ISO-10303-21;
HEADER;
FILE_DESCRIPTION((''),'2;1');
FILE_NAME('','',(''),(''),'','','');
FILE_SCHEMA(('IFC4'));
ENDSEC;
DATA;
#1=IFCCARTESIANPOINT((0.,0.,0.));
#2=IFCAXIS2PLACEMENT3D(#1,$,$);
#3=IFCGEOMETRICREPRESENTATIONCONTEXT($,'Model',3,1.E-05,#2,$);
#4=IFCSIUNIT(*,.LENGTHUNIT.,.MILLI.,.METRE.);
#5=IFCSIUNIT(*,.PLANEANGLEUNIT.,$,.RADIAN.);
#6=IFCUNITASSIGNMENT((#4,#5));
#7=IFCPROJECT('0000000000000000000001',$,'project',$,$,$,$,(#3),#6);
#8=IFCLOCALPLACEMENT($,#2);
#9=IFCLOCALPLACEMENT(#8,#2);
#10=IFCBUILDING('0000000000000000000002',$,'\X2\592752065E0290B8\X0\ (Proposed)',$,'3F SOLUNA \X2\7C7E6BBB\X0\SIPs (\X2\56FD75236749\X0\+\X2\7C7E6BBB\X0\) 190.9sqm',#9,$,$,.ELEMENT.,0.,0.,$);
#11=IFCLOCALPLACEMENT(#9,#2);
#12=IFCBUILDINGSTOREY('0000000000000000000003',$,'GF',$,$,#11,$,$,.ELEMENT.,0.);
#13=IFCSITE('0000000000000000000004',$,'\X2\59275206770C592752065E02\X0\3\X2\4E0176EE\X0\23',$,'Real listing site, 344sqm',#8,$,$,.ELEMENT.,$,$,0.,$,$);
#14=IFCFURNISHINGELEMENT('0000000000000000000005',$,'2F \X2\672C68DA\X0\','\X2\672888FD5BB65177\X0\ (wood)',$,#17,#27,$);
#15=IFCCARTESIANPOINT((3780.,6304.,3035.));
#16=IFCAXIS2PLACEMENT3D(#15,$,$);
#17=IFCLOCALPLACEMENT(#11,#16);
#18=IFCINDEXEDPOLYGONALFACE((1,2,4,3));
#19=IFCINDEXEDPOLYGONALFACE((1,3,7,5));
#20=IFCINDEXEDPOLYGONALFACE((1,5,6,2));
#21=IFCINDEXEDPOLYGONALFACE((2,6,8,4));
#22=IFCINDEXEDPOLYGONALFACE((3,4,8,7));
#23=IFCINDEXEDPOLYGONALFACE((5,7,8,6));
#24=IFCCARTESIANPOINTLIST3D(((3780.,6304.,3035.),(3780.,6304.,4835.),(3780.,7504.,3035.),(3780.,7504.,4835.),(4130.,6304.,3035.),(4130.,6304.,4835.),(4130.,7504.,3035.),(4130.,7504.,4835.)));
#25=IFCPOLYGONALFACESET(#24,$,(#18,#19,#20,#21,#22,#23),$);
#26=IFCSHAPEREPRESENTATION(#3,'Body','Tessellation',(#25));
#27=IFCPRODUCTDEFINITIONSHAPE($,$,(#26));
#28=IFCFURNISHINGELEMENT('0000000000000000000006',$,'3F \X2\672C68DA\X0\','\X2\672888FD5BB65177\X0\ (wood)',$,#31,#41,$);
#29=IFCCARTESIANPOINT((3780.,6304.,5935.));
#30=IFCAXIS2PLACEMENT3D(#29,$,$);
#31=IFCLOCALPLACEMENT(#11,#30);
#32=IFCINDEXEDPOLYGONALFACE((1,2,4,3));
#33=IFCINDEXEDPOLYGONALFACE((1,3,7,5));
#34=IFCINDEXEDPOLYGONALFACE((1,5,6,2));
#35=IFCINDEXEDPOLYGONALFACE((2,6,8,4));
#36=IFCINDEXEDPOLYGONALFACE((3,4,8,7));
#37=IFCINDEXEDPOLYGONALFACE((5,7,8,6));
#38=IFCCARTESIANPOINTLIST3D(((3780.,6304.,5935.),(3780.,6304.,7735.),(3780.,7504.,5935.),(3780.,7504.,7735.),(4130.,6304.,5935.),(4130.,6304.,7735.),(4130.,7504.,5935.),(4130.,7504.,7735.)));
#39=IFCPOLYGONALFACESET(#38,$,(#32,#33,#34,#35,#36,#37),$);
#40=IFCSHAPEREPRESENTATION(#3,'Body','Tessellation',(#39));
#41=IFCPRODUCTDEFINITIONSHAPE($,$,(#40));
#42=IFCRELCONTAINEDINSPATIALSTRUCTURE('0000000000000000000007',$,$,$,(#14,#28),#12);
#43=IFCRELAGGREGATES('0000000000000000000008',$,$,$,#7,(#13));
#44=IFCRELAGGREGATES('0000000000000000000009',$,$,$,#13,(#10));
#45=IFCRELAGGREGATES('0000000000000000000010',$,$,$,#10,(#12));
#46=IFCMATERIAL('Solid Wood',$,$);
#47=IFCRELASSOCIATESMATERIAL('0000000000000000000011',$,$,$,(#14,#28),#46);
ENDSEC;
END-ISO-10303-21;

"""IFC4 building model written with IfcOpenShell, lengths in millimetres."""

from ifc_helpers import new_model, si_unit, frame, frame_2d, origin, place, context, project, spatial, rectangle, extrude, material, element, save


model = new_model("IFC4")

# Units and contexts
model_context = context("Model", 3, precision=1e-05, world=origin())
ifc_project = project(units=[si_unit("LENGTHUNIT", "METRE", prefix="MILLI"), si_unit("PLANEANGLEUNIT", "RADIAN")], contexts=[model_context])

# Site, building, storey
site_placement = place(None, origin())
site = spatial("IfcSite", under=ifc_project, at=site_placement, Name="大分県大分市3丁目23", ObjectType="Real listing site, 344sqm", CompositionType="ELEMENT", RefElevation=0.0)
building_placement = place(site_placement, origin())
building = spatial("IfcBuilding", under=site, at=building_placement, Name="大分市邸 (Proposed)", ObjectType="3F SOLUNA 籾殻SIPs (国産杉+籾殻) 190.9sqm", CompositionType="ELEMENT", ElevationOfRefHeight=0.0, ElevationOfTerrain=0.0)
storey_placement = place(building_placement, origin())
storey = spatial("IfcBuildingStorey", under=building, at=storey_placement, Name="GF", CompositionType="ELEMENT", Elevation=0.0)

# Shared definitions
ifc_material_1 = material(Name="Solid Wood")

# Furnishing elements
furnishing_1_placement = place(storey_placement, frame((3780.0, 6304.0, 3035.0)))
element("IfcFurnishingElement", 1, at=furnishing_1_placement, inside=storey, material=ifc_material_1, Name="2F 本棚", Description="木製家具 (wood)", context=model_context, shape_type="SweptSolid", body=[
    extrude(rectangle(XDim=350.0, YDim=1200.0, at=frame_2d((175.0, 600.0))), frame((3780.0, 6304.0, 3035.0)), (0.0, 0.0, 1.0), 1800.0),
])
furnishing_2_placement = place(storey_placement, frame((3780.0, 6304.0, 5935.0)))
element("IfcFurnishingElement", 2, at=furnishing_2_placement, inside=storey, material=ifc_material_1, Name="3F 本棚", Description="木製家具 (wood)", context=model_context, shape_type="SweptSolid", body=[
    extrude(rectangle(XDim=350.0, YDim=1200.0, at=frame_2d((175.0, 600.0))), frame((3780.0, 6304.0, 5935.0)), (0.0, 0.0, 1.0), 1800.0),
])

save(model, "model.ifc")
